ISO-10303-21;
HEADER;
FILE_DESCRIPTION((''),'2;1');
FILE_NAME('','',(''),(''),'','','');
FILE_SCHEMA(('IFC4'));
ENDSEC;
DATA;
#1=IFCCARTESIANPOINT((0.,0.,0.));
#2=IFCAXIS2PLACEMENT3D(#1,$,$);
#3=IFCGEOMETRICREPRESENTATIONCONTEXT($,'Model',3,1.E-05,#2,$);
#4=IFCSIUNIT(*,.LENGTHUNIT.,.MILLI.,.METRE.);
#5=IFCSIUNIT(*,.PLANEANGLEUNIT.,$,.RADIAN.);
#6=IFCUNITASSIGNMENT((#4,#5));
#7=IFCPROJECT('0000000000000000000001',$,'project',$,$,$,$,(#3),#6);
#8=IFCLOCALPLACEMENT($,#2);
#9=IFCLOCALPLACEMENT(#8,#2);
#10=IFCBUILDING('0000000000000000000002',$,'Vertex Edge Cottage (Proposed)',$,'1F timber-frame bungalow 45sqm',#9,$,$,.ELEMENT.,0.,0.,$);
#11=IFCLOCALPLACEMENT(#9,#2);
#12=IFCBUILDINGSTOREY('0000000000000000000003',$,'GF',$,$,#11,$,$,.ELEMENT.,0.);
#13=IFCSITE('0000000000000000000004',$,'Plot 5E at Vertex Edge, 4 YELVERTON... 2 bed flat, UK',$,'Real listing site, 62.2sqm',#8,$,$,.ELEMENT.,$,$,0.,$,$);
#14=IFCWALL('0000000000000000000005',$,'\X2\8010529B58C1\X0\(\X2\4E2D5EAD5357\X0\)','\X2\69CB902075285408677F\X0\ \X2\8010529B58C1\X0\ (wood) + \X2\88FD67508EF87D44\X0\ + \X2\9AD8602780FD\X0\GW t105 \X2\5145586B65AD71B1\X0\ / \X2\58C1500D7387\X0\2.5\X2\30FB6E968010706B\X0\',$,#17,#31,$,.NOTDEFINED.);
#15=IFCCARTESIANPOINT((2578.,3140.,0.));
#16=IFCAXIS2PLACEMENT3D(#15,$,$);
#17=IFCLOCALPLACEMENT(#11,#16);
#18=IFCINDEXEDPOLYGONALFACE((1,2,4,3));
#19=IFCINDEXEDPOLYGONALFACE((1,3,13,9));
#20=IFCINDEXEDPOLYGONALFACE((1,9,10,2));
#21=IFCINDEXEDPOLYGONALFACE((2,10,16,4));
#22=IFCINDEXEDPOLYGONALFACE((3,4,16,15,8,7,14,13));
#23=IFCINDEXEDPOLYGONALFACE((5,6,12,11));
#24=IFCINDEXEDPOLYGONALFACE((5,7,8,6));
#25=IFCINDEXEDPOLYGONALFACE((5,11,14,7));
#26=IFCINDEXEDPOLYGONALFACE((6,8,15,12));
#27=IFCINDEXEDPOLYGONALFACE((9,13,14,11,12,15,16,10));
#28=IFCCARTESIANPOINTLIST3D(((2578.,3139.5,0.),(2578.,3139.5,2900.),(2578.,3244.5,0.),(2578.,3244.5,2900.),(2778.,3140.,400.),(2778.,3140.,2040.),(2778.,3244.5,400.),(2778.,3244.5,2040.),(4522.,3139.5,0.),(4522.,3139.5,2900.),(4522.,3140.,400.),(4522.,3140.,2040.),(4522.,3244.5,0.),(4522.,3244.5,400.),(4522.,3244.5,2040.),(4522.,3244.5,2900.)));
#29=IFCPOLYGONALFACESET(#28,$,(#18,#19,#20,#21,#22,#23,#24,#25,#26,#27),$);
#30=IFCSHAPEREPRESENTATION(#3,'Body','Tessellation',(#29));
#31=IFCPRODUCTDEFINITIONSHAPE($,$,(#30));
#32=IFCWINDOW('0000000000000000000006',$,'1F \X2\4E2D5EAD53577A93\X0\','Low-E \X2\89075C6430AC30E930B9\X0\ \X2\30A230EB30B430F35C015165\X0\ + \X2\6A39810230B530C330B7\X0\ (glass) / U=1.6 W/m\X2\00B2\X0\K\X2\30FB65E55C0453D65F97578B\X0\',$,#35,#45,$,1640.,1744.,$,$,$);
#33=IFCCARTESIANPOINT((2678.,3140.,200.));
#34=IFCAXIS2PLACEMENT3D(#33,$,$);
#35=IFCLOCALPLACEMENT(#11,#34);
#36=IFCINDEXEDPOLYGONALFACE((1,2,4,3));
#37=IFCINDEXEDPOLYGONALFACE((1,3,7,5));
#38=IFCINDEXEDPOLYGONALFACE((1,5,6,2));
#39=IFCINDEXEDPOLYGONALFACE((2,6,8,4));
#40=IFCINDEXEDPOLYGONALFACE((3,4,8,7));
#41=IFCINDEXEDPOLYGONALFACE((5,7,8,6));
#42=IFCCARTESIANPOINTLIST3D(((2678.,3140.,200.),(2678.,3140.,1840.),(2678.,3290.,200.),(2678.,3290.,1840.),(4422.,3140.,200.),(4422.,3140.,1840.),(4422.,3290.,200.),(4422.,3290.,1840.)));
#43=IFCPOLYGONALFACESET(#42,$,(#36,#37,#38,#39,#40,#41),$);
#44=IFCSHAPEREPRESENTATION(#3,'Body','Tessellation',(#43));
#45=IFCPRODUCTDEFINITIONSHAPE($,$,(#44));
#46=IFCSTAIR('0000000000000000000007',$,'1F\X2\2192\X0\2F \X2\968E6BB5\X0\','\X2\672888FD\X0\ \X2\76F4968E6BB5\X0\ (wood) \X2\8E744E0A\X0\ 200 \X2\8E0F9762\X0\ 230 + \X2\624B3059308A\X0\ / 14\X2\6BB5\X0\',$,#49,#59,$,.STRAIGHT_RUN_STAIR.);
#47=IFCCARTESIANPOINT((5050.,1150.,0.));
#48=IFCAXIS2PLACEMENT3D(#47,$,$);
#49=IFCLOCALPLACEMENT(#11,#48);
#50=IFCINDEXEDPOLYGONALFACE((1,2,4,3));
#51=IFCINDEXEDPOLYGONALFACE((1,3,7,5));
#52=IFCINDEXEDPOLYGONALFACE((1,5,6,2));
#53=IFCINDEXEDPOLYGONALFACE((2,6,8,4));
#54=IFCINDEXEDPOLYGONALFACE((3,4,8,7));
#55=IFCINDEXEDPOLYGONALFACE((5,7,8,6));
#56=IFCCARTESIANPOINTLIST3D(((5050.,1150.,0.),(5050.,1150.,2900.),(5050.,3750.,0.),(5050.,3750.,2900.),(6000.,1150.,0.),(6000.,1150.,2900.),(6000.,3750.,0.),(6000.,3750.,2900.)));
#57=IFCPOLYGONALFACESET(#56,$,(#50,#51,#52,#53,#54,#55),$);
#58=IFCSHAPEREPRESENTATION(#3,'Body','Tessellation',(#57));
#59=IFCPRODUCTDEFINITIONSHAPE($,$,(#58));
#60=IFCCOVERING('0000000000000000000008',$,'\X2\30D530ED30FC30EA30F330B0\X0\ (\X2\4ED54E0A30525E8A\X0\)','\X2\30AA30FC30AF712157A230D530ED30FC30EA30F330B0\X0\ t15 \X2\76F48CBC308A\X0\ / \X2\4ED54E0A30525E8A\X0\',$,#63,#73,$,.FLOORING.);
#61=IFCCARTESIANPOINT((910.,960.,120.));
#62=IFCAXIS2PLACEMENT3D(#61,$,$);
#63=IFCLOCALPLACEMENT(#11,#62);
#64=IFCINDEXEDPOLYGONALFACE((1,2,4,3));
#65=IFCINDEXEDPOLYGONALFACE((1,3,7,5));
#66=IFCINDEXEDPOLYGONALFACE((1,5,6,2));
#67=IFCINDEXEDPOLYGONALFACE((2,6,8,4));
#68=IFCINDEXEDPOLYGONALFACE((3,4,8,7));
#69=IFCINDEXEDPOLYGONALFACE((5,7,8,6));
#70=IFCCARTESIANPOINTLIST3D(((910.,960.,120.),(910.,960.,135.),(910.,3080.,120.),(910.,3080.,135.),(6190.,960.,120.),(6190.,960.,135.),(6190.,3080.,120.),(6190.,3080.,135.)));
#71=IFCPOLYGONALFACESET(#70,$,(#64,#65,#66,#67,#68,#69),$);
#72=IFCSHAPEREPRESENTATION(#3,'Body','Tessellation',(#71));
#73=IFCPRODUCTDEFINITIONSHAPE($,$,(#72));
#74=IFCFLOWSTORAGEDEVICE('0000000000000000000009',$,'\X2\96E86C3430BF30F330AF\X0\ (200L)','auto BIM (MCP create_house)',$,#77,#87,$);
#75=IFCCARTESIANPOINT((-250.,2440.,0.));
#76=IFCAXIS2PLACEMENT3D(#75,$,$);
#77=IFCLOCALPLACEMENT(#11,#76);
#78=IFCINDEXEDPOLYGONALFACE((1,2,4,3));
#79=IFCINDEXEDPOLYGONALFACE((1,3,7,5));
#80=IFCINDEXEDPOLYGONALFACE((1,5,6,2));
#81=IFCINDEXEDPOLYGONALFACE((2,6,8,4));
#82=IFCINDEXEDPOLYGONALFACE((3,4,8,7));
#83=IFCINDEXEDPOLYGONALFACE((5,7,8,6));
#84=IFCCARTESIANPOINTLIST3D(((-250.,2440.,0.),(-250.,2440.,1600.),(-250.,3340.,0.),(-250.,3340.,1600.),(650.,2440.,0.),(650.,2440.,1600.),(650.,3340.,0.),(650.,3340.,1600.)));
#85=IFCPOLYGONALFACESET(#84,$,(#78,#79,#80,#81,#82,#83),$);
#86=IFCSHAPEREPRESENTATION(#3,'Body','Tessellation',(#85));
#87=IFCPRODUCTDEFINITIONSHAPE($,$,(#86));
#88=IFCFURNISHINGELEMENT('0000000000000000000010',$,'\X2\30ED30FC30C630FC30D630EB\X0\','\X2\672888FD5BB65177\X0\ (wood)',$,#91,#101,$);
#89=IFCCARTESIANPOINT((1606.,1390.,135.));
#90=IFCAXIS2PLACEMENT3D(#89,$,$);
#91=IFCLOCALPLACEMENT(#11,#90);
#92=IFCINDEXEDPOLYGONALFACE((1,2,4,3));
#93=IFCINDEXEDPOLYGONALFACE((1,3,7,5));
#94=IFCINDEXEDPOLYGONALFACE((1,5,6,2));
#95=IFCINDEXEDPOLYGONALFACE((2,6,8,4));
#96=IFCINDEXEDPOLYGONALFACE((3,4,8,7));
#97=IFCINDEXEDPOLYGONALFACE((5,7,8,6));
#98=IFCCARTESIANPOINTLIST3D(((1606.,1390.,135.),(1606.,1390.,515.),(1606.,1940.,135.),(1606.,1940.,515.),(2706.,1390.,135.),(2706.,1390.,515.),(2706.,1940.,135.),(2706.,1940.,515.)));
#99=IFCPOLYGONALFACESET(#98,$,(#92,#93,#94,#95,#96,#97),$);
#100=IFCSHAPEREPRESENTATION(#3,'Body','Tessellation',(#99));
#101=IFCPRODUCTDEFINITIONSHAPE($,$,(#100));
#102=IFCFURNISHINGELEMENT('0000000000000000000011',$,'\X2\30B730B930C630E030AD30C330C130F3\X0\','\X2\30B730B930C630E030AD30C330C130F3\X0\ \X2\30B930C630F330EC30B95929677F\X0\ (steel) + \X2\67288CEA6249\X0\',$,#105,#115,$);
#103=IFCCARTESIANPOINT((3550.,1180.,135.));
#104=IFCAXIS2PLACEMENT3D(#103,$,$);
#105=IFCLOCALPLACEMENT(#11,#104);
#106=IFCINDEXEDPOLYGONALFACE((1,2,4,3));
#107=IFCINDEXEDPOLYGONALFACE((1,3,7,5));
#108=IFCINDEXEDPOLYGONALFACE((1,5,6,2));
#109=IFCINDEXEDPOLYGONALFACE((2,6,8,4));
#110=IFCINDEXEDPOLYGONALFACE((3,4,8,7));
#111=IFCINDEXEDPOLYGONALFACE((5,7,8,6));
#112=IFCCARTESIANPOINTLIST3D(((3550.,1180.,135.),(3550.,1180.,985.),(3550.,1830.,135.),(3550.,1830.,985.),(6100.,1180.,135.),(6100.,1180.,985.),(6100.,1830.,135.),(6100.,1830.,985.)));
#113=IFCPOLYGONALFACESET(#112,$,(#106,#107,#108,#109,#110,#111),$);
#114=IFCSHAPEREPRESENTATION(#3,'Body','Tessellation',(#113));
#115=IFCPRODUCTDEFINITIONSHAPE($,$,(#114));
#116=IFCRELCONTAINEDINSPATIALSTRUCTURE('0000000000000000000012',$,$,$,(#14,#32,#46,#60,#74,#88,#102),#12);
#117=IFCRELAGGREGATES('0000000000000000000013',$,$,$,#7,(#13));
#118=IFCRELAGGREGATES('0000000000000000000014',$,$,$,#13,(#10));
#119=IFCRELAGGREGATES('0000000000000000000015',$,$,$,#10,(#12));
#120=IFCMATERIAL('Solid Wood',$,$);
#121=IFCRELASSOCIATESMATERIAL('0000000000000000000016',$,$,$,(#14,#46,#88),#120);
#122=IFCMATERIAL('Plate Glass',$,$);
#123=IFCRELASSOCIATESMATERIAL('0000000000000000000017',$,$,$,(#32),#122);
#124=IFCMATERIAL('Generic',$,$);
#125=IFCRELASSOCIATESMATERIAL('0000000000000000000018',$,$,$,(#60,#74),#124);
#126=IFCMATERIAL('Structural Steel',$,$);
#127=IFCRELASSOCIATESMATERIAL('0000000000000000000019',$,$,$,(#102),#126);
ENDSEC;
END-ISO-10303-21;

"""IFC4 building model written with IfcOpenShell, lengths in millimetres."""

from ifc_helpers import new_model, si_unit, frame, frame_2d, origin, place, context, project, spatial, rectangle, extrude, material, element, fill, save


model = new_model("IFC4")

# Units and contexts
model_context = context("Model", 3, precision=1e-05, world=origin())
ifc_project = project(units=[si_unit("LENGTHUNIT", "METRE", prefix="MILLI"), si_unit("PLANEANGLEUNIT", "RADIAN")], contexts=[model_context])

# Site, building, storey
site_placement = place(None, origin())
site = spatial("IfcSite", under=ifc_project, at=site_placement, Name="Plot 5E at Vertex Edge, 4 YELVERTON... 2 bed flat, UK", ObjectType="Real listing site, 62.2sqm", CompositionType="ELEMENT", RefElevation=0.0)
building_placement = place(site_placement, origin())
building = spatial("IfcBuilding", under=site, at=building_placement, Name="Vertex Edge Cottage (Proposed)", ObjectType="1F timber-frame bungalow 45sqm", CompositionType="ELEMENT", ElevationOfRefHeight=0.0, ElevationOfTerrain=0.0)
storey_placement = place(building_placement, origin())
storey = spatial("IfcBuildingStorey", under=building, at=storey_placement, Name="GF", CompositionType="ELEMENT", Elevation=0.0)

# Shared definitions
ifc_material_1 = material(Name="Solid Wood")

# Shared definitions
ifc_material_2 = material(Name="Plate Glass")

# Wall, opening, window
wall_1_placement = place(storey_placement, frame((2578.0, 3140.0, 0.0)))
wall_1 = element("IfcWall", 1, at=wall_1_placement, inside=storey, material=ifc_material_1, Name="耐力壁(中庭南)", Description="構造用合板 耐力壁 (wood) + 製材軸組 + 高性能GW t105 充填断熱 / 壁倍率2.5・準耐火", PredefinedType="NOTDEFINED", context=model_context, shape_type="SweptSolid", body=[
    extrude(rectangle(XDim=1944.0, YDim=105.0, at=frame_2d((972.0, 52.0))), frame((2578.0, 3140.0, 0.0)), (0.0, 0.0, 1.0), 2900.0),
])
opening_1_placement = place(storey_placement, frame((2678.0, 3140.0, 200.0)))
opening_1 = element("IfcOpeningElement", 2, at=opening_1_placement, cuts=wall_1, PredefinedType="NOTDEFINED", context=model_context, shape_type="SweptSolid", body=[
    extrude(rectangle(XDim=1744.0, YDim=150.0, at=frame_2d((872.0, 75.0))), frame((2678.0, 3140.0, 200.0)), (0.0, 0.0, 1.0), 1640.0),
])
window_1_placement = place(storey_placement, frame((2678.0, 3140.0, 200.0)))
window_1 = element("IfcWindow", 3, at=window_1_placement, inside=storey, material=ifc_material_2, Name="1F 中庭南窓", Description="Low-E 複層ガラス アルゴン封入 + 樹脂サッシ (glass) / U=1.6 W/m²K・日射取得型", OverallHeight=1640.0, OverallWidth=1744.0, context=model_context, shape_type="SweptSolid", body=[
    extrude(rectangle(XDim=1744.0, YDim=150.0, at=frame_2d((872.0, 75.0))), frame((2678.0, 3140.0, 200.0)), (0.0, 0.0, 1.0), 1640.0),
])
fill(opening_1, window_1)

# Stair
stair_placement = place(storey_placement, frame((5050.0, 1150.0, 0.0)))
element("IfcStair", 4, at=stair_placement, inside=storey, material=ifc_material_1, Name="1F→2F 階段", Description="木製 直階段 (wood) 蹴上 200 踏面 230 + 手すり / 14段", PredefinedType="STRAIGHT_RUN_STAIR", context=model_context, shape_type="SweptSolid", body=[
    extrude(rectangle(XDim=950.0, YDim=2600.0, at=frame_2d((475.0, 1300.0))), frame((5050.0, 1150.0, 0.0)), (0.0, 0.0, 1.0), 2900.0),
])

# Covering
ifc_material_3 = material(Name="Generic")
covering_placement = place(storey_placement, frame((910.0, 960.0, 120.0)))
element("IfcCovering", 5, at=covering_placement, inside=storey, material=ifc_material_3, Name="フローリング (仕上げ床)", Description="オーク無垢フローリング t15 直貼り / 仕上げ床", PredefinedType="FLOORING", context=model_context, shape_type="SweptSolid", body=[
    extrude(rectangle(XDim=5280.0, YDim=2120.0, at=frame_2d((2640.0, 1060.0))), frame((910.0, 960.0, 120.0)), (0.0, 0.0, 1.0), 15.0),
])

# Flow storage device
flow_storage_device_placement = place(storey_placement, frame((-250.0, 2440.0, 0.0)))
element("IfcFlowStorageDevice", 6, at=flow_storage_device_placement, inside=storey, material=ifc_material_3, Name="雨水タンク (200L)", Description="auto BIM (MCP create_house)", context=model_context, shape_type="SweptSolid", body=[
    extrude(rectangle(XDim=900.0, YDim=900.0, at=frame_2d((450.0, 450.0))), frame((-250.0, 2440.0, 0.0)), (0.0, 0.0, 1.0), 1600.0),
])

# Furnishing elements
furnishing_1_placement = place(storey_placement, frame((1606.0, 1390.0, 135.0)))
element("IfcFurnishingElement", 7, at=furnishing_1_placement, inside=storey, material=ifc_material_1, Name="ローテーブル", Description="木製家具 (wood)", context=model_context, shape_type="SweptSolid", body=[
    extrude(rectangle(XDim=1100.0, YDim=550.0, at=frame_2d((550.0, 275.0))), frame((1606.0, 1390.0, 135.0)), (0.0, 0.0, 1.0), 380.0),
])
ifc_material_4 = material(Name="Structural Steel")
furnishing_2_placement = place(storey_placement, frame((3550.0, 1180.0, 135.0)))
element("IfcFurnishingElement", 8, at=furnishing_2_placement, inside=storey, material=ifc_material_4, Name="システムキッチン", Description="システムキッチン ステンレス天板 (steel) + 木質扉", context=model_context, shape_type="SweptSolid", body=[
    extrude(rectangle(XDim=2550.0, YDim=650.0, at=frame_2d((1275.0, 325.0))), frame((3550.0, 1180.0, 135.0)), (0.0, 0.0, 1.0), 850.0),
])

save(model, "model.ifc")
